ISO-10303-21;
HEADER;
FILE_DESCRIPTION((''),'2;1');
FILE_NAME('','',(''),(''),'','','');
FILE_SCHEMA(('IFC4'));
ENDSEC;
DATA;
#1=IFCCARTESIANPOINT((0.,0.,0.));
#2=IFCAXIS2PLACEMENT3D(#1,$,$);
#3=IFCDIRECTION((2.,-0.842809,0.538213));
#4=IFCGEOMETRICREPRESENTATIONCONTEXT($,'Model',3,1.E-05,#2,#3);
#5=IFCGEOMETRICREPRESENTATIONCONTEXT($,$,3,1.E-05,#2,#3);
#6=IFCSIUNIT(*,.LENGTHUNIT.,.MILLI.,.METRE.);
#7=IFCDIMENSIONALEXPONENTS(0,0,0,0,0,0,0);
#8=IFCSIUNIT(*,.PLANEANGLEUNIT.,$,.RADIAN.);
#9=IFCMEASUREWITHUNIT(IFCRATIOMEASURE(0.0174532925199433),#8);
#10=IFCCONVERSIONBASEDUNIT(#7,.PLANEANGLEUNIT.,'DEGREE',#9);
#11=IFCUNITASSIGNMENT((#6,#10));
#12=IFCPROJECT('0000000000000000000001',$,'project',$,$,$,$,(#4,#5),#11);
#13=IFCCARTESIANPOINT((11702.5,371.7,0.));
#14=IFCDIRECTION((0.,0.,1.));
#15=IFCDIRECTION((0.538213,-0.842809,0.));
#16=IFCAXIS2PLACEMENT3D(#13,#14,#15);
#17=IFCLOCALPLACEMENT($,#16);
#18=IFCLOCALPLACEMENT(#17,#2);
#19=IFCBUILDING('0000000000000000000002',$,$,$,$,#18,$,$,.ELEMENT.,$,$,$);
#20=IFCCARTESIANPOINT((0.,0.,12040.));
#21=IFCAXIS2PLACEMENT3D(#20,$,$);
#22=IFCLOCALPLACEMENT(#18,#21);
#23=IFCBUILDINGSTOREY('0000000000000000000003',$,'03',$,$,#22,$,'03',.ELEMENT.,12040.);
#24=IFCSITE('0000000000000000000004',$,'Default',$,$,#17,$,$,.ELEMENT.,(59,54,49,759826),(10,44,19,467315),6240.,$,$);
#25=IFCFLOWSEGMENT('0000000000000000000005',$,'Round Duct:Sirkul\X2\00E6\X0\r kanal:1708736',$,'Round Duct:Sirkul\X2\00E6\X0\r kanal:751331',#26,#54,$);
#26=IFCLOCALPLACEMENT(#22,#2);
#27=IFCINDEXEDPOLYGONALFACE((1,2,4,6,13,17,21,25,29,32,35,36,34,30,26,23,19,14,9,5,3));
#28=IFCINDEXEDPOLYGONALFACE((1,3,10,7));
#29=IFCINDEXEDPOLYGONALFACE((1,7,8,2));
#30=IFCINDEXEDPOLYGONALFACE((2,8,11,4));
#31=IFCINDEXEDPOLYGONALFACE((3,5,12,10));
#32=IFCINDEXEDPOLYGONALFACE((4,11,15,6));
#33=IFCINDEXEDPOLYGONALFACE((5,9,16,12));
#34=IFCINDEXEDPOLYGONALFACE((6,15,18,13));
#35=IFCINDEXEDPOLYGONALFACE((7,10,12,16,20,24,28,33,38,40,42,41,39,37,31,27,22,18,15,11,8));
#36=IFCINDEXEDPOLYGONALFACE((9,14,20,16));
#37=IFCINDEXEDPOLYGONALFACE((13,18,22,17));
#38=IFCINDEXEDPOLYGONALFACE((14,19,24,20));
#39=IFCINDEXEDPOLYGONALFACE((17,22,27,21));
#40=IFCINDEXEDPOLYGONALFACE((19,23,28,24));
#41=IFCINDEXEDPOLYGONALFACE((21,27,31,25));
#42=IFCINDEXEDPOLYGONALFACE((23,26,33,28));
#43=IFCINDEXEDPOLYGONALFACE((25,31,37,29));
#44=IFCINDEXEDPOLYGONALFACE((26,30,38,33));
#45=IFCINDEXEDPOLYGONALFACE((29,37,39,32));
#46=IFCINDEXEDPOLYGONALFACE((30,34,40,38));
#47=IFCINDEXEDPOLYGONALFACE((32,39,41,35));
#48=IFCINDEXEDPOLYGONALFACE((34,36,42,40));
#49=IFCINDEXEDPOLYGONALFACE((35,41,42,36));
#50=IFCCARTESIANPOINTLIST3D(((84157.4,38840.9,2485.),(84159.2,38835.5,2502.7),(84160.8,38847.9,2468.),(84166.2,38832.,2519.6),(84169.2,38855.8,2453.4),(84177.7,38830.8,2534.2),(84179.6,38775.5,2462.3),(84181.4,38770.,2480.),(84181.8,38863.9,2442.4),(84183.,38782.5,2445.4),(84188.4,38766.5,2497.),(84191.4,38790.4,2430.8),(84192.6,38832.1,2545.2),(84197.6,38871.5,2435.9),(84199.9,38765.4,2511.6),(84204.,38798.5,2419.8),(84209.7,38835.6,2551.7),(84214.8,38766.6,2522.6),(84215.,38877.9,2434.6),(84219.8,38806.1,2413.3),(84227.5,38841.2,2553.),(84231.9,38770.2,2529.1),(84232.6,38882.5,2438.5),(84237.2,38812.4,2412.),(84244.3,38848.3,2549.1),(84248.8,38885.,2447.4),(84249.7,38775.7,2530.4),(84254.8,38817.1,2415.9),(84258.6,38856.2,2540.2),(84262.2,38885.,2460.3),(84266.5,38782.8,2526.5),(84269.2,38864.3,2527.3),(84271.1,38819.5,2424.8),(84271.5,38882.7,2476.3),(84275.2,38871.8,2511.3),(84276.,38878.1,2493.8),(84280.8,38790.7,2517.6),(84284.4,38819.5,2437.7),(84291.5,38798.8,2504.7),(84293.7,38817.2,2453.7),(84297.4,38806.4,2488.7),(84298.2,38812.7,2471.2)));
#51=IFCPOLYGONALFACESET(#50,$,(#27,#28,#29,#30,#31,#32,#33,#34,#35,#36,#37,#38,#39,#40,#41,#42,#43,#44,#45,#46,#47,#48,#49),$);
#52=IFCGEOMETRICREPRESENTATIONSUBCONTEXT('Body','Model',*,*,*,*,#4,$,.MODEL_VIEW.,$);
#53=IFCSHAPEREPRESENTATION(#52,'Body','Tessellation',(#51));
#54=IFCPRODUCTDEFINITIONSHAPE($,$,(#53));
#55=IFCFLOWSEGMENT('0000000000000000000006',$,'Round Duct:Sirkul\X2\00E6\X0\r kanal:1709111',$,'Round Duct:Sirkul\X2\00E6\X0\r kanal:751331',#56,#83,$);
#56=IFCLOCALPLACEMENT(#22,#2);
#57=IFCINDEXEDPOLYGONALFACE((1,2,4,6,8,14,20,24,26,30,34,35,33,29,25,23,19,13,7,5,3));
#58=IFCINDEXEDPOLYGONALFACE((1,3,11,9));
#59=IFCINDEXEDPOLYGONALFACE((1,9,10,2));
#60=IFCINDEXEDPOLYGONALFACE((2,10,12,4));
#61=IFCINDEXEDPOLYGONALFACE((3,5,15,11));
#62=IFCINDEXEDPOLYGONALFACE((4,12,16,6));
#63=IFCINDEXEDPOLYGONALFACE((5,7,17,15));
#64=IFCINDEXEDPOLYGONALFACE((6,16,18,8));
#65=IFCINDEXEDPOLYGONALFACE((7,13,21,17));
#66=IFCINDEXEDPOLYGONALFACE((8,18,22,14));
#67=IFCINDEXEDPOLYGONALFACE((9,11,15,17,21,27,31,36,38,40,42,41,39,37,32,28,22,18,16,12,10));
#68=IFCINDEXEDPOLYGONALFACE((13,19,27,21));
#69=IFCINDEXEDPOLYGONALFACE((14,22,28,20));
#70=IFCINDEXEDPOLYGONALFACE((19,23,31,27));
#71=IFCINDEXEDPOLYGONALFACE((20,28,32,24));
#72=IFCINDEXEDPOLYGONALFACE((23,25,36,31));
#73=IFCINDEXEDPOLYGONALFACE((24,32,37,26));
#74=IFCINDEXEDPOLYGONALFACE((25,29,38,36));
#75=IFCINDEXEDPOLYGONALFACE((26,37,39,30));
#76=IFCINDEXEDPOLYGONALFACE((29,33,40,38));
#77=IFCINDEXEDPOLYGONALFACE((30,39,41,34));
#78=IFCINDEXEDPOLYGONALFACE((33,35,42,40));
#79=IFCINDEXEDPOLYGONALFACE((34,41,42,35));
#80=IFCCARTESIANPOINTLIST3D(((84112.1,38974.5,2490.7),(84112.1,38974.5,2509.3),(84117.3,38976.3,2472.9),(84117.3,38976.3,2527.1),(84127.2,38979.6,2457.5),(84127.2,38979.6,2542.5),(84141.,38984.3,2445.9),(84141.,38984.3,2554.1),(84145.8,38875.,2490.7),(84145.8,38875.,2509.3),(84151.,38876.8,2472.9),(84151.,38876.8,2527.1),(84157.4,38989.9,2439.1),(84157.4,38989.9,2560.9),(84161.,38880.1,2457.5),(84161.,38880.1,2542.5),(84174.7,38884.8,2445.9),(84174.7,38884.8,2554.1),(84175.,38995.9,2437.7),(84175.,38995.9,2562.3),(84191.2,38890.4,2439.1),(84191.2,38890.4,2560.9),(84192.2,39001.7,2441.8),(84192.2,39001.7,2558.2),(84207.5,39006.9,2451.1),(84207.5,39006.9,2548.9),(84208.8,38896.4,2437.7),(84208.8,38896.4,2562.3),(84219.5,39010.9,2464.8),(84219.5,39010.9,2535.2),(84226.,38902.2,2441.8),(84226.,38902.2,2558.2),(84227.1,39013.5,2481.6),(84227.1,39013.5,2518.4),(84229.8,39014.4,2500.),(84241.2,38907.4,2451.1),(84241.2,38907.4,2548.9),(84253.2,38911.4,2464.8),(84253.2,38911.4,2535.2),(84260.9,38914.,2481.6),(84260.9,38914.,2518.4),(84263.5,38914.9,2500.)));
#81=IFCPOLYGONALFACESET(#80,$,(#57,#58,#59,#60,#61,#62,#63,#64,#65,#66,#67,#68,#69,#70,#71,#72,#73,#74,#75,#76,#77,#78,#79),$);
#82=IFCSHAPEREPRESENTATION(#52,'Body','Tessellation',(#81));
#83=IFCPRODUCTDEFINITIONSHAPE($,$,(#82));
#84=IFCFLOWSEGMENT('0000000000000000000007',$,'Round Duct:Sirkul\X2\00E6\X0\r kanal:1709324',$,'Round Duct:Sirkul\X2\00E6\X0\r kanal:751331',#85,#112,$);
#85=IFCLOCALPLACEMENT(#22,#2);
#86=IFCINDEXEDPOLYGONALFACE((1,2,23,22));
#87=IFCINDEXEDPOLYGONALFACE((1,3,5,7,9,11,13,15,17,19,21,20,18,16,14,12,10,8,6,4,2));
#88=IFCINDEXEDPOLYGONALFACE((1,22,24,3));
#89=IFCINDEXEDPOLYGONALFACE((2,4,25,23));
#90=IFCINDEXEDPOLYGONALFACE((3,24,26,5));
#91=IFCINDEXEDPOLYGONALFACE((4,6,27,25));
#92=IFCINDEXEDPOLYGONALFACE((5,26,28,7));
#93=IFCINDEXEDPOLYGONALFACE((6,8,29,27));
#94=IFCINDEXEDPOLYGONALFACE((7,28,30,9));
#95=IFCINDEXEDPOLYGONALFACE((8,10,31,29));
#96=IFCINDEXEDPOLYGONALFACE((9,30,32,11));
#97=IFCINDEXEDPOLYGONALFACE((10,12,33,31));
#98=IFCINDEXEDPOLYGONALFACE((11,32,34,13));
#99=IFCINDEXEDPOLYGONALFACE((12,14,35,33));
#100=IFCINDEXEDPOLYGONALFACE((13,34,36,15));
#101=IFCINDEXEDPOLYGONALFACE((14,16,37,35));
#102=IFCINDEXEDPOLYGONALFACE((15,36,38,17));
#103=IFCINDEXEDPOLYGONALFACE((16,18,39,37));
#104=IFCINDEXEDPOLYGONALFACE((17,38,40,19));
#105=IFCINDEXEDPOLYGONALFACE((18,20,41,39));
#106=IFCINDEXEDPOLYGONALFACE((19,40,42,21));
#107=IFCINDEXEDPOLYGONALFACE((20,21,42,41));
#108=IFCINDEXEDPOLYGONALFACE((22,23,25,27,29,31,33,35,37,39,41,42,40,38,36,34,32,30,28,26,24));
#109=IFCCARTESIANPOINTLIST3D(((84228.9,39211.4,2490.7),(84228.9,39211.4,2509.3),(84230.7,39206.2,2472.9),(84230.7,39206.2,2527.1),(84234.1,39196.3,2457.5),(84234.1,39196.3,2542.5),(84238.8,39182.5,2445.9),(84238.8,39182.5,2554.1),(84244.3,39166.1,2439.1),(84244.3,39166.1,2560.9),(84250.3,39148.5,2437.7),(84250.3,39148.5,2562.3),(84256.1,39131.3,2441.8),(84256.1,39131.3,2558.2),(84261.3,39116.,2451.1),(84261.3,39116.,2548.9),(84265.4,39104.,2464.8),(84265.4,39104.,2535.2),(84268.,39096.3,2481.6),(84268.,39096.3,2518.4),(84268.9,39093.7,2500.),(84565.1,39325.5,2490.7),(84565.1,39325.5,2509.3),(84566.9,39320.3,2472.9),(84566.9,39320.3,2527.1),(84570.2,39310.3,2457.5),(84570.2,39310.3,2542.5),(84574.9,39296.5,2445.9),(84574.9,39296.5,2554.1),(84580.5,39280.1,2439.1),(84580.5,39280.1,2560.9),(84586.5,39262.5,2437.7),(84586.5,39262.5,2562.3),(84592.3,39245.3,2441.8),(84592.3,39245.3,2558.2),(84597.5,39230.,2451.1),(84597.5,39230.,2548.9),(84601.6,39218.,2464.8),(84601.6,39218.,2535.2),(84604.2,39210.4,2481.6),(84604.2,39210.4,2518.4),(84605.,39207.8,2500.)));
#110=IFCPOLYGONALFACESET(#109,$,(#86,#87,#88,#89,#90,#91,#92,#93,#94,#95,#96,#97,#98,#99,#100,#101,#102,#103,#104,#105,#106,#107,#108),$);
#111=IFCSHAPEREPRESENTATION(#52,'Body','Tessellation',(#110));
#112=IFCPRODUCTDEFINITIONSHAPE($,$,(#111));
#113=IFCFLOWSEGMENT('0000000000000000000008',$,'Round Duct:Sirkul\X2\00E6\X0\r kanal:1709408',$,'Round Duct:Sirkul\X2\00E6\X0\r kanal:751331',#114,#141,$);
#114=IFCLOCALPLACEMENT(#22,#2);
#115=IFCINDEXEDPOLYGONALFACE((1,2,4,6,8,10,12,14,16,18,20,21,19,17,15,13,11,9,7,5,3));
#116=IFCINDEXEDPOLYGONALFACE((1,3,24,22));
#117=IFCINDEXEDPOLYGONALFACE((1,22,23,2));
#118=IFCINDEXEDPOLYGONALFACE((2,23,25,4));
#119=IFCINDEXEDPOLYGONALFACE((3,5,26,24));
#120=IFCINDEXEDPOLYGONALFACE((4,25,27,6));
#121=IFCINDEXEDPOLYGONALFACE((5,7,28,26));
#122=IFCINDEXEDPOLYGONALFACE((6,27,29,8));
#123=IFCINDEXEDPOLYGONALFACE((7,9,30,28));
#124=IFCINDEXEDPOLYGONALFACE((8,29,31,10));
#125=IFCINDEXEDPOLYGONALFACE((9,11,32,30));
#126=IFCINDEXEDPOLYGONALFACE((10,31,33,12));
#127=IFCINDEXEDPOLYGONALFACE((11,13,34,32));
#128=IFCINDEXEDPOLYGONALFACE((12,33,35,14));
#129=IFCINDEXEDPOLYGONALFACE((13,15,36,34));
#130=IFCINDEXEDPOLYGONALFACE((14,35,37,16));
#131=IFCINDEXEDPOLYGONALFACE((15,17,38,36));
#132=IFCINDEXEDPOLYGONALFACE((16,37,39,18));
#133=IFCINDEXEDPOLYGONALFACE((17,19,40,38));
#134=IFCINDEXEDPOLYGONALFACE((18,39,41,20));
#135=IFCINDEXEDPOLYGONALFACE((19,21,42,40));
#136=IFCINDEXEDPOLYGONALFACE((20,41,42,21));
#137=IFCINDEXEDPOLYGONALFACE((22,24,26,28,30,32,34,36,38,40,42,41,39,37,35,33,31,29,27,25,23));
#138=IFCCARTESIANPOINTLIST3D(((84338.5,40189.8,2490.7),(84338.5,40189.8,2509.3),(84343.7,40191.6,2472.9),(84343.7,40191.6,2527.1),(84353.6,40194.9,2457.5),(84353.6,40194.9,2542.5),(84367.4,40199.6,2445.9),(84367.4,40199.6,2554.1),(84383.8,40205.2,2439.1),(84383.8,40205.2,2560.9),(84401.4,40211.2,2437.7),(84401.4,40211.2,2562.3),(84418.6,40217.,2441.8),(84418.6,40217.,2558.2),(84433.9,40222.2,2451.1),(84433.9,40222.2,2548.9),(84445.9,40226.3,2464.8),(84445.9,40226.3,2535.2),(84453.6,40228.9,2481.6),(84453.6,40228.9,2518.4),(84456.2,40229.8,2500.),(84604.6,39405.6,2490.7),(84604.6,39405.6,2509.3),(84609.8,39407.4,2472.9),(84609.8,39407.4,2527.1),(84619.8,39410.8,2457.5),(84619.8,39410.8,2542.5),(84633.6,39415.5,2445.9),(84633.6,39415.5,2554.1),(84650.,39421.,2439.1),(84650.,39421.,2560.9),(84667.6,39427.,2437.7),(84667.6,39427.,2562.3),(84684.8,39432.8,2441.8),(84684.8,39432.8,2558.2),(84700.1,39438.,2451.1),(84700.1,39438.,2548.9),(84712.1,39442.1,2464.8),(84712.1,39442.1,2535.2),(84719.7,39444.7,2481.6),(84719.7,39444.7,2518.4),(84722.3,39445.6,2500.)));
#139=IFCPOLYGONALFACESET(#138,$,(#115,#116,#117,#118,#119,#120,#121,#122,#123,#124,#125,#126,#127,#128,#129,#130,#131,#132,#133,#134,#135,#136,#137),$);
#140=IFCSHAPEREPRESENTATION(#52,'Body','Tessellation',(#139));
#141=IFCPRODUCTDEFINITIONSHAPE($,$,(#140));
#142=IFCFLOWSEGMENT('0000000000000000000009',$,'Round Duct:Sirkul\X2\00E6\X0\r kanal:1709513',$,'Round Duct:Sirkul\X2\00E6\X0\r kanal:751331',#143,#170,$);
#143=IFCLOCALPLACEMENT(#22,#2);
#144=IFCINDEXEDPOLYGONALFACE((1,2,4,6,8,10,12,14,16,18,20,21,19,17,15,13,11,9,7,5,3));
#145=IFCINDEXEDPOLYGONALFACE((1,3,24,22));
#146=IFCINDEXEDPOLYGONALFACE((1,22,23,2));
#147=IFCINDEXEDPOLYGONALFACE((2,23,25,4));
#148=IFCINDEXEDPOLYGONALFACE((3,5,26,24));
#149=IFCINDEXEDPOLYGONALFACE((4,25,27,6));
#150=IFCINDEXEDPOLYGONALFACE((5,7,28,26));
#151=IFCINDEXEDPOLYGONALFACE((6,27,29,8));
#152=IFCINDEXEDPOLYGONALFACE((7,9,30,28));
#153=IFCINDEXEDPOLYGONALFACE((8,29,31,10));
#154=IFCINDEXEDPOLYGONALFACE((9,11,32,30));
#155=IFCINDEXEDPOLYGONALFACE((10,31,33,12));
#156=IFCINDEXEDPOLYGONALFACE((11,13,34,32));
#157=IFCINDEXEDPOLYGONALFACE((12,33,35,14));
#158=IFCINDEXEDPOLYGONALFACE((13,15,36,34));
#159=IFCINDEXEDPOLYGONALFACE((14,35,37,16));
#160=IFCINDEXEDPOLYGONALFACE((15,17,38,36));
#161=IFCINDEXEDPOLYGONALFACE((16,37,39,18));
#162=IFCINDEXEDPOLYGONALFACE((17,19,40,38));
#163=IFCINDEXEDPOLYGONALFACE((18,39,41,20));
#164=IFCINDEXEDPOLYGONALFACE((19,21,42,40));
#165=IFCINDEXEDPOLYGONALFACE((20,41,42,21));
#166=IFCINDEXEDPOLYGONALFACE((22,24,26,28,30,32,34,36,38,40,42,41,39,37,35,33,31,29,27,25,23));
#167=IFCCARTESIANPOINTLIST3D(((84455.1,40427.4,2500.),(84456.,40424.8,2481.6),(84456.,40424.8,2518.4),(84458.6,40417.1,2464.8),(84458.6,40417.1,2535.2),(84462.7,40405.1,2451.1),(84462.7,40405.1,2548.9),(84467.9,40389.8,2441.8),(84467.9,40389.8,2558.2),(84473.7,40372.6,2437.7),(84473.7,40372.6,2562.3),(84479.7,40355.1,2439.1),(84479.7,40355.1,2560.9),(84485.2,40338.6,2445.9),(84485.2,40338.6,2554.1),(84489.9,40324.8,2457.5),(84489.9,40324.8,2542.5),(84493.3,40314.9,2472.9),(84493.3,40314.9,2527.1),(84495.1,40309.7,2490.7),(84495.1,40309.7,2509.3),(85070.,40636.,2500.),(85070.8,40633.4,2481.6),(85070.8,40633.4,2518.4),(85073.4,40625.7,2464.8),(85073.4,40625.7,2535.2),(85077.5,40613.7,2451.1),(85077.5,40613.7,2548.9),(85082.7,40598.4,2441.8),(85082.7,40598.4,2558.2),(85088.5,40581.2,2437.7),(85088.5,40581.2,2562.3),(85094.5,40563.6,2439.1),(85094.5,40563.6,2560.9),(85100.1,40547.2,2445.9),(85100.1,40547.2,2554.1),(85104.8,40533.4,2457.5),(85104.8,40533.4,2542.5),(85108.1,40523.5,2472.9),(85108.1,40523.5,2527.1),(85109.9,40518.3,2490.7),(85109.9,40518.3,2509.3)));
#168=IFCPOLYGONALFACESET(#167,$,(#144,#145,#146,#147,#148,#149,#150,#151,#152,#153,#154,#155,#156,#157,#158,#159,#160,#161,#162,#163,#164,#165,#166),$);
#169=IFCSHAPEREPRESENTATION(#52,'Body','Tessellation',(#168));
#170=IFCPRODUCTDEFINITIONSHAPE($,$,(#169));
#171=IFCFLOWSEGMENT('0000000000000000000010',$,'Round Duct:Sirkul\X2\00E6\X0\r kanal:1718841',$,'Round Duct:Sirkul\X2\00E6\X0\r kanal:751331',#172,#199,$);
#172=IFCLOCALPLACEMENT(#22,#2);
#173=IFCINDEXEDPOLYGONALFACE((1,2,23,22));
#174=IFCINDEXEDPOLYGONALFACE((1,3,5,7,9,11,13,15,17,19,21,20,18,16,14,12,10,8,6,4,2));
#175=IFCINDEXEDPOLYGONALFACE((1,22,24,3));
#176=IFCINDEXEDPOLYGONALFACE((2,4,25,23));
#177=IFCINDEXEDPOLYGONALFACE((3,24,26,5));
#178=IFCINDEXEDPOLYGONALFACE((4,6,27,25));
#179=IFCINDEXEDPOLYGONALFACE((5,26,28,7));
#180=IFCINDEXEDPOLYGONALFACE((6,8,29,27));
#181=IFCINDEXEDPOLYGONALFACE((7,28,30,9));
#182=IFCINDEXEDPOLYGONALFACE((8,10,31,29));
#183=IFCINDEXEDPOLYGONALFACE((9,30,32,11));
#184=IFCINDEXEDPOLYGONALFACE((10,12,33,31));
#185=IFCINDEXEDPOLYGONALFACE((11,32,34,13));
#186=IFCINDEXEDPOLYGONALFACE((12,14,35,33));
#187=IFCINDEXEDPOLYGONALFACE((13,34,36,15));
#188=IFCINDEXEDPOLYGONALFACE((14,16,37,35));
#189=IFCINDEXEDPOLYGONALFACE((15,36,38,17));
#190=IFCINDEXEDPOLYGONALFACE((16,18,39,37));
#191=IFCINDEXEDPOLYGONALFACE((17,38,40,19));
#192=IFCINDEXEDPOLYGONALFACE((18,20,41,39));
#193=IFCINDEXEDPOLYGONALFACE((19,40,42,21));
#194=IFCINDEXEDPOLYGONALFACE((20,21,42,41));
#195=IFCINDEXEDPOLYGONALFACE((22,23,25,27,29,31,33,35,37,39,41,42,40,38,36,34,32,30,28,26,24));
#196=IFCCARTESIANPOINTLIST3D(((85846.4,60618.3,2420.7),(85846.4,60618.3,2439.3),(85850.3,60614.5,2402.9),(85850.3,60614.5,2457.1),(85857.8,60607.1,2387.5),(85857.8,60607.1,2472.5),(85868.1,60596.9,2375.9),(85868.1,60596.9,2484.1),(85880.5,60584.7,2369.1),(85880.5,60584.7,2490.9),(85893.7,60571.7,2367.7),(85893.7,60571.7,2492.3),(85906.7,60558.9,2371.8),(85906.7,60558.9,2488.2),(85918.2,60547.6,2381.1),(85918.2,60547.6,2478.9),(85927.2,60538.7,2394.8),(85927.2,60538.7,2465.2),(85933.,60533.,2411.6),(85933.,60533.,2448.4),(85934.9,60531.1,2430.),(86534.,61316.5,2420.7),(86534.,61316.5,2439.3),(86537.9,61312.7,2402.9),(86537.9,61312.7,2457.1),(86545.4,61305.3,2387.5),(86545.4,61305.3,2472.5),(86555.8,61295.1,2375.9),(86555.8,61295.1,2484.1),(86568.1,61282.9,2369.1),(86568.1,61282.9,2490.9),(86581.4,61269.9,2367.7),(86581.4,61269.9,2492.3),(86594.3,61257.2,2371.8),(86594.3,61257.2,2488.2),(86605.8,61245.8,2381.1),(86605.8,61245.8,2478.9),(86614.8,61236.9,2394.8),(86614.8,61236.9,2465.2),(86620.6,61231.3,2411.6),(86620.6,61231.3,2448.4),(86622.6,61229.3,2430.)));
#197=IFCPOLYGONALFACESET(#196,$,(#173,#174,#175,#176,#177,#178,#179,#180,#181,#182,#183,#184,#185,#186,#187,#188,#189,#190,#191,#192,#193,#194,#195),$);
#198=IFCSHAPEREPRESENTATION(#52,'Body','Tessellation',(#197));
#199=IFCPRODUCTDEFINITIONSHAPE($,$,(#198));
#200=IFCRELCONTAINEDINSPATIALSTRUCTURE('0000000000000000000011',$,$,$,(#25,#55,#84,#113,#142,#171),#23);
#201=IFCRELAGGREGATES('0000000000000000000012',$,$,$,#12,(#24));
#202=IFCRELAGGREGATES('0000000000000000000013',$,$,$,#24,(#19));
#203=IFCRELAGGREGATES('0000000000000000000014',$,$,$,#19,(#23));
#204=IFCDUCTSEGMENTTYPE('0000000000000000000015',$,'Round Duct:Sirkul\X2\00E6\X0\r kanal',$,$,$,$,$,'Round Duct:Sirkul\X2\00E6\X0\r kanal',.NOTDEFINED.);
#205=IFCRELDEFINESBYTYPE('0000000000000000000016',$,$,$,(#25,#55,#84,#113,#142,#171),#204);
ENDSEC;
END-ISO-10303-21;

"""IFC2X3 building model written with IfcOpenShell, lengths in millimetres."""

from ifc_helpers import new_model, entity, si_unit, converted_unit, direction, frame, frame_2d, origin, origin_2d_with_axis, place, context, subcontext, project, spatial, circle, extrude, type_object, element, save


model = new_model("IFC2X3")

# Units and contexts
model_context = context("Model", 3, precision=1e-05, world=origin(), true_north=direction((2.0, -0.842809, 0.538213)))
context_of_model = context(None, 3, precision=1e-05, world=origin(), true_north=direction((2.0, -0.842809, 0.538213)))
body_context = subcontext(model_context, "Body", "Model", "MODEL_VIEW")
ifc_project = project(units=[si_unit("LENGTHUNIT", "METRE", prefix="MILLI"), converted_unit("PLANEANGLEUNIT", "DEGREE", entity("IfcRatioMeasure", 0.0174532925199433), si_unit("PLANEANGLEUNIT", "RADIAN"), dimensions=[0, 0, 0, 0, 0, 0, 0])], contexts=[model_context, context_of_model])

# Site, building, storey
site_placement = place(None, frame((11702.5, 371.7, 0.0), z_axis=(0.0, 0.0, 1.0), x_axis=(0.538213, -0.842809, 0.0)))
site = spatial("IfcSite", under=ifc_project, at=site_placement, Name="Default", CompositionType="ELEMENT", RefLatitude=(59, 54, 49, 759826), RefLongitude=(10, 44, 19, 467315), RefElevation=6240.0)
building_placement = place(site_placement, origin())
building = spatial("IfcBuilding", under=site, at=building_placement, CompositionType="ELEMENT")
storey_placement = place(building_placement, frame((0.0, 0.0, 12040.0)))
storey = spatial("IfcBuildingStorey", under=building, at=storey_placement, Name="03", LongName="03", CompositionType="ELEMENT", Elevation=12040.0)

# Flow segments
duct_segment_type = type_object("IfcDuctSegmentType", Name="Round Duct:Sirkulær kanal", ElementType="Round Duct:Sirkulær kanal", PredefinedType="NOTDEFINED")
flow_segment_1_placement = place(storey_placement, origin())
element("IfcFlowSegment", 1, at=flow_segment_1_placement, inside=storey, type_object=duct_segment_type, Name="Round Duct:Sirkulær kanal:1708736", ObjectType="Round Duct:Sirkulær kanal:751331", context=body_context, shape_type="SweptSolid", body=[
    extrude(circle(Radius=62.5, at=origin_2d_with_axis()), frame((84239.0, 38792.6, 2471.2), z_axis=(-0.305326, 0.900067, 0.310893), x_axis=(0.946996, 0.321245, 0.0)), (0.0, 0.0, 1.0), 72.7),
])
flow_segment_2_placement = place(storey_placement, origin())
element("IfcFlowSegment", 2, at=flow_segment_2_placement, inside=storey, type_object=duct_segment_type, Name="Round Duct:Sirkulær kanal:1709111", ObjectType="Round Duct:Sirkulær kanal:751331", context=body_context, shape_type="SweptSolid", body=[
    extrude(circle(Radius=62.5, at=origin_2d_with_axis()), frame((84170.6, 38994.4, 2500.0), z_axis=(0.321267, -0.946989, 0.0), x_axis=(0.946989, 0.321267, 0.0)), (0.0, 0.0, 1.0), 105.1),
])
flow_segment_3_placement = place(storey_placement, origin())
element("IfcFlowSegment", 3, at=flow_segment_3_placement, inside=storey, type_object=duct_segment_type, Name="Round Duct:Sirkulær kanal:1709324", ObjectType="Round Duct:Sirkulær kanal:751331", context=body_context, shape_type="SweptSolid", body=[
    extrude(circle(Radius=62.5, at=origin_2d_with_axis()), frame((84248.8, 39152.9, 2500.0), z_axis=(0.946976, 0.321305, 0.0), x_axis=(0.321305, -0.946976, 0.0)), (0.0, 0.0, 1.0), 355.0),
])
flow_segment_4_placement = place(storey_placement, origin())
element("IfcFlowSegment", 4, at=flow_segment_4_placement, inside=storey, type_object=duct_segment_type, Name="Round Duct:Sirkulær kanal:1709408", ObjectType="Round Duct:Sirkulær kanal:751331", context=body_context, shape_type="SweptSolid", body=[
    extrude(circle(Radius=62.5, at=origin_2d_with_axis()), frame((84663.2, 39425.5, 2500.0), z_axis=(-0.321413, 0.946939, 0.0), x_axis=(0.946939, 0.321413, 0.0)), (0.0, 0.0, 1.0), 828.1),
])
flow_segment_5_placement = place(storey_placement, origin())
element("IfcFlowSegment", 5, at=flow_segment_5_placement, inside=storey, type_object=duct_segment_type, Name="Round Duct:Sirkulær kanal:1709513", ObjectType="Round Duct:Sirkulær kanal:751331", context=body_context, shape_type="SweptSolid", body=[
    extrude(circle(Radius=62.5, at=frame_2d((0.0, 0.0), x_axis=(1.0, 0.0))), frame((84475.2, 40368.2, 2500.0), z_axis=(0.946986, 0.321274, 0.0), x_axis=(-0.321274, 0.946986, 0.0)), (0.0, 0.0, 1.0), 649.2),
])
flow_segment_6_placement = place(storey_placement, origin())
element("IfcFlowSegment", 6, at=flow_segment_6_placement, inside=storey, type_object=duct_segment_type, Name="Round Duct:Sirkulær kanal:1718841", ObjectType="Round Duct:Sirkulær kanal:751331", context=body_context, shape_type="SweptSolid", body=[
    extrude(circle(Radius=62.5, at=frame_2d((0.0, 0.0), x_axis=(1.0, 0.0))), frame((85890.4, 60574.9, 2430.0), z_axis=(0.701682, 0.71249, 0.0), x_axis=(0.71249, -0.701682, 0.0)), (0.0, 0.0, 1.0), 980.0),
])

save(model, "model.ifc")
